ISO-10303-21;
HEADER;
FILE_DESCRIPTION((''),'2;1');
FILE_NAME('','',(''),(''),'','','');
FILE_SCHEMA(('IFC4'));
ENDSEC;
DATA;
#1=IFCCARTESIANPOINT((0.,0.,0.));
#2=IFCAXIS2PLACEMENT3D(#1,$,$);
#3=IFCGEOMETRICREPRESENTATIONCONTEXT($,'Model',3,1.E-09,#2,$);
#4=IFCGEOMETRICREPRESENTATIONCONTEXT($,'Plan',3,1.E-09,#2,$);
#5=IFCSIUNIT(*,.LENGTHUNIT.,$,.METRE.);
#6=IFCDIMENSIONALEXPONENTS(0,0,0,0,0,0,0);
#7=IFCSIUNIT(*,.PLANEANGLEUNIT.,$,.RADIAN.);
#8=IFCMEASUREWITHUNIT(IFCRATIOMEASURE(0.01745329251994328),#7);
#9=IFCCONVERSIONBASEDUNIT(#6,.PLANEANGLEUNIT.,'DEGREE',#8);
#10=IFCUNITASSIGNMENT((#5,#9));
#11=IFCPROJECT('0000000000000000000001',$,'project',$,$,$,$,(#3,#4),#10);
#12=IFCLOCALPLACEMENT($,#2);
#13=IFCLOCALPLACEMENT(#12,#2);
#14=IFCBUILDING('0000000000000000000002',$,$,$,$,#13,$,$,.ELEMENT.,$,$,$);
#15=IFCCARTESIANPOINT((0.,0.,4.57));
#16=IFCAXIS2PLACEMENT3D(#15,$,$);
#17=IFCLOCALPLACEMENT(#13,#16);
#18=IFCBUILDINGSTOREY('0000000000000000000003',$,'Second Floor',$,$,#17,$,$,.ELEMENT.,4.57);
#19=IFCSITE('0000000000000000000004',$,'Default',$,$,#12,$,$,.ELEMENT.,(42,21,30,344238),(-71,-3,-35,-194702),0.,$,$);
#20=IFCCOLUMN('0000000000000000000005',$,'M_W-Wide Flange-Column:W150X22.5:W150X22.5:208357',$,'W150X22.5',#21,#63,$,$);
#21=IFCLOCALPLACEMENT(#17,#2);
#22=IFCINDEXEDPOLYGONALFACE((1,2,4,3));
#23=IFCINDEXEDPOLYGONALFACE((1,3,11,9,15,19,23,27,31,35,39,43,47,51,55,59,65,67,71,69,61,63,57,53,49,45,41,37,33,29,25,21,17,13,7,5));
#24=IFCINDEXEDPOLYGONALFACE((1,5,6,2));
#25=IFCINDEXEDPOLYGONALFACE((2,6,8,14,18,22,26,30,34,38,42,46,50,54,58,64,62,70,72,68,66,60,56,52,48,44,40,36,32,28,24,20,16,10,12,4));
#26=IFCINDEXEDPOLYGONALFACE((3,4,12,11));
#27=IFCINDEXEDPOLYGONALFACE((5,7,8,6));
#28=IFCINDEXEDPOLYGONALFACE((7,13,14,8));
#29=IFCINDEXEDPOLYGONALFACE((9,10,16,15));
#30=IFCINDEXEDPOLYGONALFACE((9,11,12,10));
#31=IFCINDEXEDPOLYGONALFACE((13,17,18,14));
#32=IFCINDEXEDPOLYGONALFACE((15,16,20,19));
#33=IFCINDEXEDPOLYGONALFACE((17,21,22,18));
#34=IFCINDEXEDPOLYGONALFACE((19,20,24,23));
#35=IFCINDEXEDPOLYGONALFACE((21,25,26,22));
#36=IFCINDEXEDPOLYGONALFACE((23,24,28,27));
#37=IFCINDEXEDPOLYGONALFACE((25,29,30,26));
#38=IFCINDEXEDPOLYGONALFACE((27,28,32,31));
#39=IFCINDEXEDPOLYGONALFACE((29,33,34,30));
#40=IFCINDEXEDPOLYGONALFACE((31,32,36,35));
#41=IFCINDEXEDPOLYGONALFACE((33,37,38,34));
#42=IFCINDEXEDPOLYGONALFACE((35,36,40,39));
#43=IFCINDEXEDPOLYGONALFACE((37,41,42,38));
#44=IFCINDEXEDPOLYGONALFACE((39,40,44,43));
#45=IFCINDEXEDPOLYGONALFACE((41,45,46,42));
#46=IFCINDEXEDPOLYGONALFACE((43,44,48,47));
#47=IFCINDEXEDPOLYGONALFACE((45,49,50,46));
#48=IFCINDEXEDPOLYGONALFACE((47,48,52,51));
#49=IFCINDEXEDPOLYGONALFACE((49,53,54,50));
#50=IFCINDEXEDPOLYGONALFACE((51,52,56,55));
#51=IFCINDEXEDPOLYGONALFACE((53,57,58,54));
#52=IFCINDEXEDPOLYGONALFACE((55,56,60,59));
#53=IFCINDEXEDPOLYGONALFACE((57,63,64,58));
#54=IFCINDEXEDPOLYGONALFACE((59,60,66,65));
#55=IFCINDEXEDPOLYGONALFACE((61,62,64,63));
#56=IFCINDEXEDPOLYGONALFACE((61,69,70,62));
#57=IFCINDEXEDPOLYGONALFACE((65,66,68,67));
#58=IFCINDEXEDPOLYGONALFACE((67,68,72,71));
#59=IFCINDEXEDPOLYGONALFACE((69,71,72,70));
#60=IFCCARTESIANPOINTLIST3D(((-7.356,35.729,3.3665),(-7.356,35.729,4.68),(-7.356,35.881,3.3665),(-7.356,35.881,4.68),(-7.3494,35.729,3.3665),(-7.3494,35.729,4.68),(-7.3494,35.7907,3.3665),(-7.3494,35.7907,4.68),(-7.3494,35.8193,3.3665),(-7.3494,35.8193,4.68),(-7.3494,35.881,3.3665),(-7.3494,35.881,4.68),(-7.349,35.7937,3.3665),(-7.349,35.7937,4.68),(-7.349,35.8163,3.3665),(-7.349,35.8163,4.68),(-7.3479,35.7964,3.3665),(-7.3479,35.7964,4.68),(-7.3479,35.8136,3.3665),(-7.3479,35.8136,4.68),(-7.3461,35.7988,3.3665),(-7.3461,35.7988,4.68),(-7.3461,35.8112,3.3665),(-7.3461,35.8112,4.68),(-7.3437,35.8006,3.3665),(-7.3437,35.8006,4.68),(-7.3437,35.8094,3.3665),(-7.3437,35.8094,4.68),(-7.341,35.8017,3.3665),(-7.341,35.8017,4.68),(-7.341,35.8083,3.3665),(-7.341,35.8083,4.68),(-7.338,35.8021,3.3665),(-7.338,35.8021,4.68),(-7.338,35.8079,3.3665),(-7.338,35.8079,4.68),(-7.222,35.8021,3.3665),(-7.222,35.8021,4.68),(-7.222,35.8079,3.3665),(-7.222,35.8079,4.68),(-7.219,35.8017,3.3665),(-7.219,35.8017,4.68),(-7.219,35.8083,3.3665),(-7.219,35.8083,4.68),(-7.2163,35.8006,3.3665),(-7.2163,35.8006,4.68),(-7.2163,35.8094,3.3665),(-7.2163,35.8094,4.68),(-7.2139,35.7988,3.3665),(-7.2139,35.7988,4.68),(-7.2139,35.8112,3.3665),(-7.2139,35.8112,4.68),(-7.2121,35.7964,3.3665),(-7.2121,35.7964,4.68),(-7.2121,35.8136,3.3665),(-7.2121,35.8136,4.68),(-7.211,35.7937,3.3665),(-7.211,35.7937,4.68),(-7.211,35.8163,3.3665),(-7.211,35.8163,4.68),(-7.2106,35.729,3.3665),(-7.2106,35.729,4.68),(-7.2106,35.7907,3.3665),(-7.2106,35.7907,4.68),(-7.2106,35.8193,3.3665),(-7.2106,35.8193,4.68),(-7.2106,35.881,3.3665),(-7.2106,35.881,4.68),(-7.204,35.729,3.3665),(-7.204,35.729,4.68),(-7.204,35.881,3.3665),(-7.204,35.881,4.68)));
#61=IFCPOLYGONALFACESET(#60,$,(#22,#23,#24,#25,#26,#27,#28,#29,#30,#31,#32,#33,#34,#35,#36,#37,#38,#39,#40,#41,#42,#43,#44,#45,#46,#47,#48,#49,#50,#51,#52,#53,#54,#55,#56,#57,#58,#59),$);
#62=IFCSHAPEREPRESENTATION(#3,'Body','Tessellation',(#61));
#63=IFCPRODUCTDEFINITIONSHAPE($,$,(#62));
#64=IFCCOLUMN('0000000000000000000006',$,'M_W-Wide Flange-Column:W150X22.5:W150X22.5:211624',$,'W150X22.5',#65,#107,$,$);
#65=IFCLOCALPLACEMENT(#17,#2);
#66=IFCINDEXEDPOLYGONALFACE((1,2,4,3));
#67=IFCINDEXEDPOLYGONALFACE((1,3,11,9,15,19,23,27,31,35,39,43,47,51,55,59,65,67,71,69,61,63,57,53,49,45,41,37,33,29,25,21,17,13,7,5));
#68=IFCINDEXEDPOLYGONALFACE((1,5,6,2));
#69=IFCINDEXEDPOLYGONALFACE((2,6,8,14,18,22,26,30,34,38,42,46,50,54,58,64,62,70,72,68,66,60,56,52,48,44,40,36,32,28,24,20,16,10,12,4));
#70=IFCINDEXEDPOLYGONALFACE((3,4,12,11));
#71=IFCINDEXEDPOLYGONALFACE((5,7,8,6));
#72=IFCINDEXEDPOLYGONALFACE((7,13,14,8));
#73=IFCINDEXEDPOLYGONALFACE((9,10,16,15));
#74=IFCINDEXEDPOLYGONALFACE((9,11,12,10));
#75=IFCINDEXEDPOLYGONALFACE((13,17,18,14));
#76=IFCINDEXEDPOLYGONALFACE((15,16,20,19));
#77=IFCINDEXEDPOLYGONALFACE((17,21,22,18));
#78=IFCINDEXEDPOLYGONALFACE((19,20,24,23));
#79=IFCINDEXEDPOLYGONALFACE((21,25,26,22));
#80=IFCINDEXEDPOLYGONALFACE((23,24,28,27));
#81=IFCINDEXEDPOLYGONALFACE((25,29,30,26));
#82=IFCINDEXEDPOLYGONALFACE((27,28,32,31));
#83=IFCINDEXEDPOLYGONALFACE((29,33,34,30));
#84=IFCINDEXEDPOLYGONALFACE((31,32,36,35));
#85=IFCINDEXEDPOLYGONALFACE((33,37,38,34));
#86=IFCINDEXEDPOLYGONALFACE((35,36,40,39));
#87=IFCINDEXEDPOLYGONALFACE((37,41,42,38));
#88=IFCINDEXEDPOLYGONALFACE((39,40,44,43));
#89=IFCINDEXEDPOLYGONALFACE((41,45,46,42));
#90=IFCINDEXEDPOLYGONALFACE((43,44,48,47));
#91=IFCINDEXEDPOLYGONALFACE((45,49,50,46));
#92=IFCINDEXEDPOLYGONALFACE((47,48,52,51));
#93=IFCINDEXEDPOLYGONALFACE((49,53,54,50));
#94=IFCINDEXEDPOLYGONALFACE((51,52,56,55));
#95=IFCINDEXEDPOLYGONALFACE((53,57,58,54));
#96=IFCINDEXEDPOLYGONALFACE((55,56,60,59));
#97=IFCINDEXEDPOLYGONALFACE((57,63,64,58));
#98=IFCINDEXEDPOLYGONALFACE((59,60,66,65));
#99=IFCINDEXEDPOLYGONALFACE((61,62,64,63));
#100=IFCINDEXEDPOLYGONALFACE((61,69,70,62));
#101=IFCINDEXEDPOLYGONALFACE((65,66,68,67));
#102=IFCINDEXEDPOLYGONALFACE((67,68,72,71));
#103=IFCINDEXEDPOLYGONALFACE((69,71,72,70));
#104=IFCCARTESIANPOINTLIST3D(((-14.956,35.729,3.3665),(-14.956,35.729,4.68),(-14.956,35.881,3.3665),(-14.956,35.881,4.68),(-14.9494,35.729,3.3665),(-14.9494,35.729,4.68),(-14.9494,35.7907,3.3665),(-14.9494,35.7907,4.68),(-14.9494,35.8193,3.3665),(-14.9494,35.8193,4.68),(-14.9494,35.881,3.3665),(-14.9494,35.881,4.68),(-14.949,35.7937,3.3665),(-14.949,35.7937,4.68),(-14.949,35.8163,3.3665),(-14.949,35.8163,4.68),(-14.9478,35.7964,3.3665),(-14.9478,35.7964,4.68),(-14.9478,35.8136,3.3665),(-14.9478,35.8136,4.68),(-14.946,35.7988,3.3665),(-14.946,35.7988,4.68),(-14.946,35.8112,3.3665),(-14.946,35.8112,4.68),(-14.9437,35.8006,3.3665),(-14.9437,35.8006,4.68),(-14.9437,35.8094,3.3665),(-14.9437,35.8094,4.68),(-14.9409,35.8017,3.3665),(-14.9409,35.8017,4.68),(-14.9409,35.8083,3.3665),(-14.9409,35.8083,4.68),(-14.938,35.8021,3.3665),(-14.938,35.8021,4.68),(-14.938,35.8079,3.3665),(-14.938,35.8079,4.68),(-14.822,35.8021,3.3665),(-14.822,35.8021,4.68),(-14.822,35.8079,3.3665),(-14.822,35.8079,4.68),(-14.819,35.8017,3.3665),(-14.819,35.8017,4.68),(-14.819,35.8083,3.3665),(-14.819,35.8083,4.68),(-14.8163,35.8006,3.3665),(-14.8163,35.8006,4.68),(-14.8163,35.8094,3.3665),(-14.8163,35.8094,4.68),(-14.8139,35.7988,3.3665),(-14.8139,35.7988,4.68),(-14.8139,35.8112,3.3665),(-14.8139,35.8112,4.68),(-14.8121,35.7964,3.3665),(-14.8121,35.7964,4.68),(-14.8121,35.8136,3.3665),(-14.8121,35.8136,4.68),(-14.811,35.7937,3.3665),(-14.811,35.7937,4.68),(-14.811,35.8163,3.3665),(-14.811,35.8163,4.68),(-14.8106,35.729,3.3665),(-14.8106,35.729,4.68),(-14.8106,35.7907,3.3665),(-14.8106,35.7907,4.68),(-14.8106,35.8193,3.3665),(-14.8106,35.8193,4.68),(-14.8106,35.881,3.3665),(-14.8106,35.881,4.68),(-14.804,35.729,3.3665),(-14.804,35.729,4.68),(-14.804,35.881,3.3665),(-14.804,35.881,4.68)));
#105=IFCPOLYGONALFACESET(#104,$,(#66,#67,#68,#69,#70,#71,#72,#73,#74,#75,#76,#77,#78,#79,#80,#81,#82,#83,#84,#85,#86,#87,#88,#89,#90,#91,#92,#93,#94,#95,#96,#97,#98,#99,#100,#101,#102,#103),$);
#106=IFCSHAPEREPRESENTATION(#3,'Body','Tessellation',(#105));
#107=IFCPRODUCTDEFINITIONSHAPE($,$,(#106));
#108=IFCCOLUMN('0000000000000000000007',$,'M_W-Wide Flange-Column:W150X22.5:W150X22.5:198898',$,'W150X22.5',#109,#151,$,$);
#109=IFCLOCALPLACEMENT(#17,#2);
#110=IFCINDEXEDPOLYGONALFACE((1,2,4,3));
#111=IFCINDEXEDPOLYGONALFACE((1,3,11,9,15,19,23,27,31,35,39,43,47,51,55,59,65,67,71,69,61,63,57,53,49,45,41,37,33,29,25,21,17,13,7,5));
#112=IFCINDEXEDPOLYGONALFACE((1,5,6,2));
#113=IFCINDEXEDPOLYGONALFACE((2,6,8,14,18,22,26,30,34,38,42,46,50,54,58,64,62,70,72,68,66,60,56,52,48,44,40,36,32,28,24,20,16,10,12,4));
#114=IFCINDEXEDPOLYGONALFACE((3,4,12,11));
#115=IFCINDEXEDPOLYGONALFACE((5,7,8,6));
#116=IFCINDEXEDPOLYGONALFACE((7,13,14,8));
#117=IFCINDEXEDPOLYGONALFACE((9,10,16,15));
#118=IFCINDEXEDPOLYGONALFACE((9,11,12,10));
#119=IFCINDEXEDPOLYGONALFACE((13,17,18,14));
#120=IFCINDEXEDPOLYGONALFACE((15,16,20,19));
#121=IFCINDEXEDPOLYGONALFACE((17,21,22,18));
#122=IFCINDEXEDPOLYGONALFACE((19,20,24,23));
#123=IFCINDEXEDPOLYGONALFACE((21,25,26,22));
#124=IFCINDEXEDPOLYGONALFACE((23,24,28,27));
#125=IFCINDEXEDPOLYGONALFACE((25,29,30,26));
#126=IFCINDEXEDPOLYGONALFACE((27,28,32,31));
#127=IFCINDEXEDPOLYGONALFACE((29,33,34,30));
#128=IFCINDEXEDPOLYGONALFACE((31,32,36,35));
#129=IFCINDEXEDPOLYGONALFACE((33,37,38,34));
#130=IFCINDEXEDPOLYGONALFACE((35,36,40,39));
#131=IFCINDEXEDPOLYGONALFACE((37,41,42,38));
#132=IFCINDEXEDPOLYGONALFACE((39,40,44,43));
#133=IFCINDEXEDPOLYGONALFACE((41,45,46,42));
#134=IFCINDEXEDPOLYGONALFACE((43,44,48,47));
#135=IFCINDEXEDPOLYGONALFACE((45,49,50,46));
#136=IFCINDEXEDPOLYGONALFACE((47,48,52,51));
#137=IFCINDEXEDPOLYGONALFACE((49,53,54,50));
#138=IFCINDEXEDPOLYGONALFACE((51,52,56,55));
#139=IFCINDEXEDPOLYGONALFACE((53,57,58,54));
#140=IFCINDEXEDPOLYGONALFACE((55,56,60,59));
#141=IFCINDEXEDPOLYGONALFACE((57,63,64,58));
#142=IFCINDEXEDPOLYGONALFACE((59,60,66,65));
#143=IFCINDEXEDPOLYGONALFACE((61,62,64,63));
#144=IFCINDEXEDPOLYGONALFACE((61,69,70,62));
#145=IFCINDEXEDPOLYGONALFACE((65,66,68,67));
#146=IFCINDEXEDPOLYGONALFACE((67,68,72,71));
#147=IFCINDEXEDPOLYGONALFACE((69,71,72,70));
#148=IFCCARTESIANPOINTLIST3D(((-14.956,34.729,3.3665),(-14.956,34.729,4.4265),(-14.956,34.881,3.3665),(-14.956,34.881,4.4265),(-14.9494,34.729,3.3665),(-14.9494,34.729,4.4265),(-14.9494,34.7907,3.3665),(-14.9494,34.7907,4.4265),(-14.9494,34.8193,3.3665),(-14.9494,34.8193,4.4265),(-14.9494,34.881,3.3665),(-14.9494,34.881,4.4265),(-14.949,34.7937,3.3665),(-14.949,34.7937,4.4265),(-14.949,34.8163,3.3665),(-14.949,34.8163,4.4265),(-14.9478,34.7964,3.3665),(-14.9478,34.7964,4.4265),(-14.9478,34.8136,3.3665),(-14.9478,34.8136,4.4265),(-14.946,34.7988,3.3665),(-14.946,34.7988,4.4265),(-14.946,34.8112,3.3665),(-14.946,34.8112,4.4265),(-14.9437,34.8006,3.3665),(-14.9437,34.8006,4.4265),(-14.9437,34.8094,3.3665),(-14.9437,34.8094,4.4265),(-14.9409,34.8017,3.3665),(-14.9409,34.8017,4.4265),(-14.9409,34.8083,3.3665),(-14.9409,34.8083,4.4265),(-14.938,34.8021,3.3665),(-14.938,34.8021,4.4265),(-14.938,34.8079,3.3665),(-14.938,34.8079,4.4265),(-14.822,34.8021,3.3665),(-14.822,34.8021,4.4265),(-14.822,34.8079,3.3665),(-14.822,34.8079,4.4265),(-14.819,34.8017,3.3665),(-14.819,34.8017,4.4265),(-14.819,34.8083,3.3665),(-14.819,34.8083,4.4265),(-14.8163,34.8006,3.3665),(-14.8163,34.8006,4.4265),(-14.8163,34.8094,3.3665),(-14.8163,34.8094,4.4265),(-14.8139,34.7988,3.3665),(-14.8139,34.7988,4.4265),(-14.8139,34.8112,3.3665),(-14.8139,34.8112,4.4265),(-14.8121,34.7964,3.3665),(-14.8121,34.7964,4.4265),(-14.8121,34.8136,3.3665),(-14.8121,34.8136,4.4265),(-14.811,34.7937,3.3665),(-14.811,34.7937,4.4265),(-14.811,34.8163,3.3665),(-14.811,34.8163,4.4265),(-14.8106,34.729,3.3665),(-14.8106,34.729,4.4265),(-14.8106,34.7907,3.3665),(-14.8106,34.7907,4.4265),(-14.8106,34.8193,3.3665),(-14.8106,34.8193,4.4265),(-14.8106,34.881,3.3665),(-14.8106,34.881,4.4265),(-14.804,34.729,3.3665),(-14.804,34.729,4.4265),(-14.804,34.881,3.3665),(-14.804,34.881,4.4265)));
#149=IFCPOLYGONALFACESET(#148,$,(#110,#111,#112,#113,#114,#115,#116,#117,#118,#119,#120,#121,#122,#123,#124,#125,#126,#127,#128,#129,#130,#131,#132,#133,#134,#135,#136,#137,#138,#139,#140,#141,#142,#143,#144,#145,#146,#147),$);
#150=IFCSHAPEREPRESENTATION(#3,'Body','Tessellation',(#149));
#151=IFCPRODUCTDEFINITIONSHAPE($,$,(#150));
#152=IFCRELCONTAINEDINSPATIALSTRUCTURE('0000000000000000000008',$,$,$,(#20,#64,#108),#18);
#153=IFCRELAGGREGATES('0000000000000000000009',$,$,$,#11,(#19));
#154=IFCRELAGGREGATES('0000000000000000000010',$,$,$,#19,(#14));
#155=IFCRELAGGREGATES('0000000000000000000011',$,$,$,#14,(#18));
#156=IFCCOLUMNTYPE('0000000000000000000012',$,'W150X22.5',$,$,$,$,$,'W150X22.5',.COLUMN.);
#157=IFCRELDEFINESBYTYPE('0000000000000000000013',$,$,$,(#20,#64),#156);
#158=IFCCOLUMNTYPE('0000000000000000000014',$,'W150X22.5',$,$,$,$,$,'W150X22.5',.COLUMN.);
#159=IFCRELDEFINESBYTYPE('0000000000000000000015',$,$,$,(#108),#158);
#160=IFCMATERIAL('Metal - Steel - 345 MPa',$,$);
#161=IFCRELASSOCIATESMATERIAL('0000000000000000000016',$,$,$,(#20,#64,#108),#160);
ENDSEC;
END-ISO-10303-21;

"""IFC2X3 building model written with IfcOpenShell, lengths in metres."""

from ifc_helpers import new_model, entity, si_unit, converted_unit, frame, frame_2d, origin, place, context, project, spatial, polyline, circle_curve, parameter, trimmed, segment, composite_curve, outline, extrude, source, transform, mapped, material, type_object, type_shapes, element, save


model = new_model("IFC2X3")

# Units and contexts
model_context = context("Model", 3, precision=1e-09, world=origin())
plan_context = context("Plan", 3, precision=1e-09, world=origin())
ifc_project = project(units=[si_unit("LENGTHUNIT", "METRE"), converted_unit("PLANEANGLEUNIT", "DEGREE", entity("IfcRatioMeasure", 0.01745329251994328), si_unit("PLANEANGLEUNIT", "RADIAN"), dimensions=[0, 0, 0, 0, 0, 0, 0])], contexts=[model_context, plan_context])

# Site, building, storey
site_placement = place(None, origin())
site = spatial("IfcSite", under=ifc_project, at=site_placement, Name="Default", CompositionType="ELEMENT", RefLatitude=(42, 21, 30, 344238), RefLongitude=(-71, -3, -35, -194702), RefElevation=0.0)
building_placement = place(site_placement, origin())
building = spatial("IfcBuilding", under=site, at=building_placement, CompositionType="ELEMENT")
storey_placement = place(building_placement, frame((0.0, 0.0, 4.57)))
storey = spatial("IfcBuildingStorey", under=building, at=storey_placement, Name="Second Floor", CompositionType="ELEMENT", Elevation=4.57)

# Columns
ifc_material = material(Name="Metal - Steel - 345 MPa")
column_type_1 = type_object("IfcColumnType", Name="W150X22.5", ElementType="W150X22.5", PredefinedType="COLUMN")
shared_shape_1 = source(origin(), model_context, "Body", "SweptSolid", [
    extrude(outline(composite_curve([segment(polyline([(-0.076, -0.076), (0.076, -0.076)]), True, "CONTINUOUS"), segment(polyline([(0.076, -0.076), (0.076, -0.0694)]), True, "CONTINUOUS"), segment(polyline([(0.076, -0.0694), (0.0143, -0.0694)]), True, "CONTINUOUS"), segment(trimmed(circle_curve(frame_2d((0.0143, -0.058), x_axis=(-1.0, 0.0)), 0.0114), [parameter(0.0)], [parameter(90.0)], True, "PARAMETER"), False, "CONTINUOUS"), segment(polyline([(0.0029, -0.058), (0.0029, 0.058)]), True, "CONTINUOUS"), segment(trimmed(circle_curve(frame_2d((0.0143, 0.058), x_axis=(-1.0, 0.0)), 0.0114), [parameter(270.0)], [parameter(0.0)], True, "PARAMETER"), False, "CONTINUOUS"), segment(polyline([(0.0143, 0.0694), (0.076, 0.0694)]), True, "CONTINUOUS"), segment(polyline([(0.076, 0.0694), (0.076, 0.076)]), True, "CONTINUOUS"), segment(polyline([(0.076, 0.076), (-0.076, 0.076)]), True, "CONTINUOUS"), segment(polyline([(-0.076, 0.076), (-0.076, 0.0694)]), True, "CONTINUOUS"), segment(polyline([(-0.076, 0.0694), (-0.0143, 0.0694)]), True, "CONTINUOUS"), segment(trimmed(circle_curve(frame_2d((-0.0143, 0.058), x_axis=(-1.0, 0.0)), 0.0114), [parameter(180.0)], [parameter(270.0)], True, "PARAMETER"), False, "CONTINUOUS"), segment(polyline([(-0.0029, 0.058), (-0.0029, -0.058)]), True, "CONTINUOUS"), segment(trimmed(circle_curve(frame_2d((-0.0143, -0.058), x_axis=(-1.0, 0.0)), 0.0114), [parameter(90.0)], [parameter(180.0)], True, "PARAMETER"), False, "CONTINUOUS"), segment(polyline([(-0.0143, -0.0694), (-0.076, -0.0694)]), True, "CONTINUOUS"), segment(polyline([(-0.076, -0.0694), (-0.076, -0.076)]), True, "CONTINUOUS")], self_intersect=False)), frame((0.0, 0.0, 7.9365), z_axis=(0.0, 0.0, 1.0), x_axis=(-1.0, 0.0, 0.0)), (0.0, 0.0, 1.0), 1.3135),
])
type_shapes(column_type_1, [shared_shape_1])
for number, where, z_axis, x_axis, name in (
    (1, (-7.28, 35.805, -4.57), (0.0, 0.0, 1.0), (0.0, 1.0, 0.0), "M_W-Wide Flange-Column:W150X22.5:W150X22.5:208357"),
    (2, (-14.88, 35.805, -4.57), (0.0, 0.0, 1.0), (0.0, 1.0, 0.0), "M_W-Wide Flange-Column:W150X22.5:W150X22.5:211624"),
):
    element("IfcColumn", number, at=place(storey_placement, frame(where, z_axis=z_axis, x_axis=x_axis)), inside=storey, type_object=column_type_1, material=ifc_material, Name=name, ObjectType="W150X22.5", context=model_context, shape_type="MappedRepresentation", body=[
        mapped(shared_shape_1, transform((0.0, 0.0, 0.0), scale=1.0)),
    ])
column_type_2 = type_object("IfcColumnType", Name="W150X22.5", ElementType="W150X22.5", PredefinedType="COLUMN")
shared_shape_2 = source(origin(), model_context, "Body", "SweptSolid", [
    extrude(outline(composite_curve([segment(polyline([(-0.076, -0.076), (0.076, -0.076)]), True, "CONTINUOUS"), segment(polyline([(0.076, -0.076), (0.076, -0.0694)]), True, "CONTINUOUS"), segment(polyline([(0.076, -0.0694), (0.0143, -0.0694)]), True, "CONTINUOUS"), segment(trimmed(circle_curve(frame_2d((0.0143, -0.058), x_axis=(-1.0, 0.0)), 0.0114), [parameter(0.0)], [parameter(90.0)], True, "PARAMETER"), False, "CONTINUOUS"), segment(polyline([(0.0029, -0.058), (0.0029, 0.058)]), True, "CONTINUOUS"), segment(trimmed(circle_curve(frame_2d((0.0143, 0.058), x_axis=(-1.0, 0.0)), 0.0114), [parameter(270.0)], [parameter(0.0)], True, "PARAMETER"), False, "CONTINUOUS"), segment(polyline([(0.0143, 0.0694), (0.076, 0.0694)]), True, "CONTINUOUS"), segment(polyline([(0.076, 0.0694), (0.076, 0.076)]), True, "CONTINUOUS"), segment(polyline([(0.076, 0.076), (-0.076, 0.076)]), True, "CONTINUOUS"), segment(polyline([(-0.076, 0.076), (-0.076, 0.0694)]), True, "CONTINUOUS"), segment(polyline([(-0.076, 0.0694), (-0.0143, 0.0694)]), True, "CONTINUOUS"), segment(trimmed(circle_curve(frame_2d((-0.0143, 0.058), x_axis=(-1.0, 0.0)), 0.0114), [parameter(180.0)], [parameter(270.0)], True, "PARAMETER"), False, "CONTINUOUS"), segment(polyline([(-0.0029, 0.058), (-0.0029, -0.058)]), True, "CONTINUOUS"), segment(trimmed(circle_curve(frame_2d((-0.0143, -0.058), x_axis=(-1.0, 0.0)), 0.0114), [parameter(90.0)], [parameter(180.0)], True, "PARAMETER"), False, "CONTINUOUS"), segment(polyline([(-0.0143, -0.0694), (-0.076, -0.0694)]), True, "CONTINUOUS"), segment(polyline([(-0.076, -0.0694), (-0.076, -0.076)]), True, "CONTINUOUS")], self_intersect=False)), frame((0.0, 0.0, 7.9365), z_axis=(0.0, 0.0, 1.0), x_axis=(-1.0, 0.0, 0.0)), (0.0, 0.0, 1.0), 1.06),
])
type_shapes(column_type_2, [shared_shape_2])
for number, where, z_axis, x_axis, name in (
    (3, (-14.88, 34.805, -4.57), (0.0, 0.0, 1.0), (0.0, 1.0, 0.0), "M_W-Wide Flange-Column:W150X22.5:W150X22.5:198898"),
):
    element("IfcColumn", number, at=place(storey_placement, frame(where, z_axis=z_axis, x_axis=x_axis)), inside=storey, type_object=column_type_2, material=ifc_material, Name=name, ObjectType="W150X22.5", context=model_context, shape_type="MappedRepresentation", body=[
        mapped(shared_shape_2, transform((0.0, 0.0, 0.0), scale=1.0)),
    ])

save(model, "model.ifc")
